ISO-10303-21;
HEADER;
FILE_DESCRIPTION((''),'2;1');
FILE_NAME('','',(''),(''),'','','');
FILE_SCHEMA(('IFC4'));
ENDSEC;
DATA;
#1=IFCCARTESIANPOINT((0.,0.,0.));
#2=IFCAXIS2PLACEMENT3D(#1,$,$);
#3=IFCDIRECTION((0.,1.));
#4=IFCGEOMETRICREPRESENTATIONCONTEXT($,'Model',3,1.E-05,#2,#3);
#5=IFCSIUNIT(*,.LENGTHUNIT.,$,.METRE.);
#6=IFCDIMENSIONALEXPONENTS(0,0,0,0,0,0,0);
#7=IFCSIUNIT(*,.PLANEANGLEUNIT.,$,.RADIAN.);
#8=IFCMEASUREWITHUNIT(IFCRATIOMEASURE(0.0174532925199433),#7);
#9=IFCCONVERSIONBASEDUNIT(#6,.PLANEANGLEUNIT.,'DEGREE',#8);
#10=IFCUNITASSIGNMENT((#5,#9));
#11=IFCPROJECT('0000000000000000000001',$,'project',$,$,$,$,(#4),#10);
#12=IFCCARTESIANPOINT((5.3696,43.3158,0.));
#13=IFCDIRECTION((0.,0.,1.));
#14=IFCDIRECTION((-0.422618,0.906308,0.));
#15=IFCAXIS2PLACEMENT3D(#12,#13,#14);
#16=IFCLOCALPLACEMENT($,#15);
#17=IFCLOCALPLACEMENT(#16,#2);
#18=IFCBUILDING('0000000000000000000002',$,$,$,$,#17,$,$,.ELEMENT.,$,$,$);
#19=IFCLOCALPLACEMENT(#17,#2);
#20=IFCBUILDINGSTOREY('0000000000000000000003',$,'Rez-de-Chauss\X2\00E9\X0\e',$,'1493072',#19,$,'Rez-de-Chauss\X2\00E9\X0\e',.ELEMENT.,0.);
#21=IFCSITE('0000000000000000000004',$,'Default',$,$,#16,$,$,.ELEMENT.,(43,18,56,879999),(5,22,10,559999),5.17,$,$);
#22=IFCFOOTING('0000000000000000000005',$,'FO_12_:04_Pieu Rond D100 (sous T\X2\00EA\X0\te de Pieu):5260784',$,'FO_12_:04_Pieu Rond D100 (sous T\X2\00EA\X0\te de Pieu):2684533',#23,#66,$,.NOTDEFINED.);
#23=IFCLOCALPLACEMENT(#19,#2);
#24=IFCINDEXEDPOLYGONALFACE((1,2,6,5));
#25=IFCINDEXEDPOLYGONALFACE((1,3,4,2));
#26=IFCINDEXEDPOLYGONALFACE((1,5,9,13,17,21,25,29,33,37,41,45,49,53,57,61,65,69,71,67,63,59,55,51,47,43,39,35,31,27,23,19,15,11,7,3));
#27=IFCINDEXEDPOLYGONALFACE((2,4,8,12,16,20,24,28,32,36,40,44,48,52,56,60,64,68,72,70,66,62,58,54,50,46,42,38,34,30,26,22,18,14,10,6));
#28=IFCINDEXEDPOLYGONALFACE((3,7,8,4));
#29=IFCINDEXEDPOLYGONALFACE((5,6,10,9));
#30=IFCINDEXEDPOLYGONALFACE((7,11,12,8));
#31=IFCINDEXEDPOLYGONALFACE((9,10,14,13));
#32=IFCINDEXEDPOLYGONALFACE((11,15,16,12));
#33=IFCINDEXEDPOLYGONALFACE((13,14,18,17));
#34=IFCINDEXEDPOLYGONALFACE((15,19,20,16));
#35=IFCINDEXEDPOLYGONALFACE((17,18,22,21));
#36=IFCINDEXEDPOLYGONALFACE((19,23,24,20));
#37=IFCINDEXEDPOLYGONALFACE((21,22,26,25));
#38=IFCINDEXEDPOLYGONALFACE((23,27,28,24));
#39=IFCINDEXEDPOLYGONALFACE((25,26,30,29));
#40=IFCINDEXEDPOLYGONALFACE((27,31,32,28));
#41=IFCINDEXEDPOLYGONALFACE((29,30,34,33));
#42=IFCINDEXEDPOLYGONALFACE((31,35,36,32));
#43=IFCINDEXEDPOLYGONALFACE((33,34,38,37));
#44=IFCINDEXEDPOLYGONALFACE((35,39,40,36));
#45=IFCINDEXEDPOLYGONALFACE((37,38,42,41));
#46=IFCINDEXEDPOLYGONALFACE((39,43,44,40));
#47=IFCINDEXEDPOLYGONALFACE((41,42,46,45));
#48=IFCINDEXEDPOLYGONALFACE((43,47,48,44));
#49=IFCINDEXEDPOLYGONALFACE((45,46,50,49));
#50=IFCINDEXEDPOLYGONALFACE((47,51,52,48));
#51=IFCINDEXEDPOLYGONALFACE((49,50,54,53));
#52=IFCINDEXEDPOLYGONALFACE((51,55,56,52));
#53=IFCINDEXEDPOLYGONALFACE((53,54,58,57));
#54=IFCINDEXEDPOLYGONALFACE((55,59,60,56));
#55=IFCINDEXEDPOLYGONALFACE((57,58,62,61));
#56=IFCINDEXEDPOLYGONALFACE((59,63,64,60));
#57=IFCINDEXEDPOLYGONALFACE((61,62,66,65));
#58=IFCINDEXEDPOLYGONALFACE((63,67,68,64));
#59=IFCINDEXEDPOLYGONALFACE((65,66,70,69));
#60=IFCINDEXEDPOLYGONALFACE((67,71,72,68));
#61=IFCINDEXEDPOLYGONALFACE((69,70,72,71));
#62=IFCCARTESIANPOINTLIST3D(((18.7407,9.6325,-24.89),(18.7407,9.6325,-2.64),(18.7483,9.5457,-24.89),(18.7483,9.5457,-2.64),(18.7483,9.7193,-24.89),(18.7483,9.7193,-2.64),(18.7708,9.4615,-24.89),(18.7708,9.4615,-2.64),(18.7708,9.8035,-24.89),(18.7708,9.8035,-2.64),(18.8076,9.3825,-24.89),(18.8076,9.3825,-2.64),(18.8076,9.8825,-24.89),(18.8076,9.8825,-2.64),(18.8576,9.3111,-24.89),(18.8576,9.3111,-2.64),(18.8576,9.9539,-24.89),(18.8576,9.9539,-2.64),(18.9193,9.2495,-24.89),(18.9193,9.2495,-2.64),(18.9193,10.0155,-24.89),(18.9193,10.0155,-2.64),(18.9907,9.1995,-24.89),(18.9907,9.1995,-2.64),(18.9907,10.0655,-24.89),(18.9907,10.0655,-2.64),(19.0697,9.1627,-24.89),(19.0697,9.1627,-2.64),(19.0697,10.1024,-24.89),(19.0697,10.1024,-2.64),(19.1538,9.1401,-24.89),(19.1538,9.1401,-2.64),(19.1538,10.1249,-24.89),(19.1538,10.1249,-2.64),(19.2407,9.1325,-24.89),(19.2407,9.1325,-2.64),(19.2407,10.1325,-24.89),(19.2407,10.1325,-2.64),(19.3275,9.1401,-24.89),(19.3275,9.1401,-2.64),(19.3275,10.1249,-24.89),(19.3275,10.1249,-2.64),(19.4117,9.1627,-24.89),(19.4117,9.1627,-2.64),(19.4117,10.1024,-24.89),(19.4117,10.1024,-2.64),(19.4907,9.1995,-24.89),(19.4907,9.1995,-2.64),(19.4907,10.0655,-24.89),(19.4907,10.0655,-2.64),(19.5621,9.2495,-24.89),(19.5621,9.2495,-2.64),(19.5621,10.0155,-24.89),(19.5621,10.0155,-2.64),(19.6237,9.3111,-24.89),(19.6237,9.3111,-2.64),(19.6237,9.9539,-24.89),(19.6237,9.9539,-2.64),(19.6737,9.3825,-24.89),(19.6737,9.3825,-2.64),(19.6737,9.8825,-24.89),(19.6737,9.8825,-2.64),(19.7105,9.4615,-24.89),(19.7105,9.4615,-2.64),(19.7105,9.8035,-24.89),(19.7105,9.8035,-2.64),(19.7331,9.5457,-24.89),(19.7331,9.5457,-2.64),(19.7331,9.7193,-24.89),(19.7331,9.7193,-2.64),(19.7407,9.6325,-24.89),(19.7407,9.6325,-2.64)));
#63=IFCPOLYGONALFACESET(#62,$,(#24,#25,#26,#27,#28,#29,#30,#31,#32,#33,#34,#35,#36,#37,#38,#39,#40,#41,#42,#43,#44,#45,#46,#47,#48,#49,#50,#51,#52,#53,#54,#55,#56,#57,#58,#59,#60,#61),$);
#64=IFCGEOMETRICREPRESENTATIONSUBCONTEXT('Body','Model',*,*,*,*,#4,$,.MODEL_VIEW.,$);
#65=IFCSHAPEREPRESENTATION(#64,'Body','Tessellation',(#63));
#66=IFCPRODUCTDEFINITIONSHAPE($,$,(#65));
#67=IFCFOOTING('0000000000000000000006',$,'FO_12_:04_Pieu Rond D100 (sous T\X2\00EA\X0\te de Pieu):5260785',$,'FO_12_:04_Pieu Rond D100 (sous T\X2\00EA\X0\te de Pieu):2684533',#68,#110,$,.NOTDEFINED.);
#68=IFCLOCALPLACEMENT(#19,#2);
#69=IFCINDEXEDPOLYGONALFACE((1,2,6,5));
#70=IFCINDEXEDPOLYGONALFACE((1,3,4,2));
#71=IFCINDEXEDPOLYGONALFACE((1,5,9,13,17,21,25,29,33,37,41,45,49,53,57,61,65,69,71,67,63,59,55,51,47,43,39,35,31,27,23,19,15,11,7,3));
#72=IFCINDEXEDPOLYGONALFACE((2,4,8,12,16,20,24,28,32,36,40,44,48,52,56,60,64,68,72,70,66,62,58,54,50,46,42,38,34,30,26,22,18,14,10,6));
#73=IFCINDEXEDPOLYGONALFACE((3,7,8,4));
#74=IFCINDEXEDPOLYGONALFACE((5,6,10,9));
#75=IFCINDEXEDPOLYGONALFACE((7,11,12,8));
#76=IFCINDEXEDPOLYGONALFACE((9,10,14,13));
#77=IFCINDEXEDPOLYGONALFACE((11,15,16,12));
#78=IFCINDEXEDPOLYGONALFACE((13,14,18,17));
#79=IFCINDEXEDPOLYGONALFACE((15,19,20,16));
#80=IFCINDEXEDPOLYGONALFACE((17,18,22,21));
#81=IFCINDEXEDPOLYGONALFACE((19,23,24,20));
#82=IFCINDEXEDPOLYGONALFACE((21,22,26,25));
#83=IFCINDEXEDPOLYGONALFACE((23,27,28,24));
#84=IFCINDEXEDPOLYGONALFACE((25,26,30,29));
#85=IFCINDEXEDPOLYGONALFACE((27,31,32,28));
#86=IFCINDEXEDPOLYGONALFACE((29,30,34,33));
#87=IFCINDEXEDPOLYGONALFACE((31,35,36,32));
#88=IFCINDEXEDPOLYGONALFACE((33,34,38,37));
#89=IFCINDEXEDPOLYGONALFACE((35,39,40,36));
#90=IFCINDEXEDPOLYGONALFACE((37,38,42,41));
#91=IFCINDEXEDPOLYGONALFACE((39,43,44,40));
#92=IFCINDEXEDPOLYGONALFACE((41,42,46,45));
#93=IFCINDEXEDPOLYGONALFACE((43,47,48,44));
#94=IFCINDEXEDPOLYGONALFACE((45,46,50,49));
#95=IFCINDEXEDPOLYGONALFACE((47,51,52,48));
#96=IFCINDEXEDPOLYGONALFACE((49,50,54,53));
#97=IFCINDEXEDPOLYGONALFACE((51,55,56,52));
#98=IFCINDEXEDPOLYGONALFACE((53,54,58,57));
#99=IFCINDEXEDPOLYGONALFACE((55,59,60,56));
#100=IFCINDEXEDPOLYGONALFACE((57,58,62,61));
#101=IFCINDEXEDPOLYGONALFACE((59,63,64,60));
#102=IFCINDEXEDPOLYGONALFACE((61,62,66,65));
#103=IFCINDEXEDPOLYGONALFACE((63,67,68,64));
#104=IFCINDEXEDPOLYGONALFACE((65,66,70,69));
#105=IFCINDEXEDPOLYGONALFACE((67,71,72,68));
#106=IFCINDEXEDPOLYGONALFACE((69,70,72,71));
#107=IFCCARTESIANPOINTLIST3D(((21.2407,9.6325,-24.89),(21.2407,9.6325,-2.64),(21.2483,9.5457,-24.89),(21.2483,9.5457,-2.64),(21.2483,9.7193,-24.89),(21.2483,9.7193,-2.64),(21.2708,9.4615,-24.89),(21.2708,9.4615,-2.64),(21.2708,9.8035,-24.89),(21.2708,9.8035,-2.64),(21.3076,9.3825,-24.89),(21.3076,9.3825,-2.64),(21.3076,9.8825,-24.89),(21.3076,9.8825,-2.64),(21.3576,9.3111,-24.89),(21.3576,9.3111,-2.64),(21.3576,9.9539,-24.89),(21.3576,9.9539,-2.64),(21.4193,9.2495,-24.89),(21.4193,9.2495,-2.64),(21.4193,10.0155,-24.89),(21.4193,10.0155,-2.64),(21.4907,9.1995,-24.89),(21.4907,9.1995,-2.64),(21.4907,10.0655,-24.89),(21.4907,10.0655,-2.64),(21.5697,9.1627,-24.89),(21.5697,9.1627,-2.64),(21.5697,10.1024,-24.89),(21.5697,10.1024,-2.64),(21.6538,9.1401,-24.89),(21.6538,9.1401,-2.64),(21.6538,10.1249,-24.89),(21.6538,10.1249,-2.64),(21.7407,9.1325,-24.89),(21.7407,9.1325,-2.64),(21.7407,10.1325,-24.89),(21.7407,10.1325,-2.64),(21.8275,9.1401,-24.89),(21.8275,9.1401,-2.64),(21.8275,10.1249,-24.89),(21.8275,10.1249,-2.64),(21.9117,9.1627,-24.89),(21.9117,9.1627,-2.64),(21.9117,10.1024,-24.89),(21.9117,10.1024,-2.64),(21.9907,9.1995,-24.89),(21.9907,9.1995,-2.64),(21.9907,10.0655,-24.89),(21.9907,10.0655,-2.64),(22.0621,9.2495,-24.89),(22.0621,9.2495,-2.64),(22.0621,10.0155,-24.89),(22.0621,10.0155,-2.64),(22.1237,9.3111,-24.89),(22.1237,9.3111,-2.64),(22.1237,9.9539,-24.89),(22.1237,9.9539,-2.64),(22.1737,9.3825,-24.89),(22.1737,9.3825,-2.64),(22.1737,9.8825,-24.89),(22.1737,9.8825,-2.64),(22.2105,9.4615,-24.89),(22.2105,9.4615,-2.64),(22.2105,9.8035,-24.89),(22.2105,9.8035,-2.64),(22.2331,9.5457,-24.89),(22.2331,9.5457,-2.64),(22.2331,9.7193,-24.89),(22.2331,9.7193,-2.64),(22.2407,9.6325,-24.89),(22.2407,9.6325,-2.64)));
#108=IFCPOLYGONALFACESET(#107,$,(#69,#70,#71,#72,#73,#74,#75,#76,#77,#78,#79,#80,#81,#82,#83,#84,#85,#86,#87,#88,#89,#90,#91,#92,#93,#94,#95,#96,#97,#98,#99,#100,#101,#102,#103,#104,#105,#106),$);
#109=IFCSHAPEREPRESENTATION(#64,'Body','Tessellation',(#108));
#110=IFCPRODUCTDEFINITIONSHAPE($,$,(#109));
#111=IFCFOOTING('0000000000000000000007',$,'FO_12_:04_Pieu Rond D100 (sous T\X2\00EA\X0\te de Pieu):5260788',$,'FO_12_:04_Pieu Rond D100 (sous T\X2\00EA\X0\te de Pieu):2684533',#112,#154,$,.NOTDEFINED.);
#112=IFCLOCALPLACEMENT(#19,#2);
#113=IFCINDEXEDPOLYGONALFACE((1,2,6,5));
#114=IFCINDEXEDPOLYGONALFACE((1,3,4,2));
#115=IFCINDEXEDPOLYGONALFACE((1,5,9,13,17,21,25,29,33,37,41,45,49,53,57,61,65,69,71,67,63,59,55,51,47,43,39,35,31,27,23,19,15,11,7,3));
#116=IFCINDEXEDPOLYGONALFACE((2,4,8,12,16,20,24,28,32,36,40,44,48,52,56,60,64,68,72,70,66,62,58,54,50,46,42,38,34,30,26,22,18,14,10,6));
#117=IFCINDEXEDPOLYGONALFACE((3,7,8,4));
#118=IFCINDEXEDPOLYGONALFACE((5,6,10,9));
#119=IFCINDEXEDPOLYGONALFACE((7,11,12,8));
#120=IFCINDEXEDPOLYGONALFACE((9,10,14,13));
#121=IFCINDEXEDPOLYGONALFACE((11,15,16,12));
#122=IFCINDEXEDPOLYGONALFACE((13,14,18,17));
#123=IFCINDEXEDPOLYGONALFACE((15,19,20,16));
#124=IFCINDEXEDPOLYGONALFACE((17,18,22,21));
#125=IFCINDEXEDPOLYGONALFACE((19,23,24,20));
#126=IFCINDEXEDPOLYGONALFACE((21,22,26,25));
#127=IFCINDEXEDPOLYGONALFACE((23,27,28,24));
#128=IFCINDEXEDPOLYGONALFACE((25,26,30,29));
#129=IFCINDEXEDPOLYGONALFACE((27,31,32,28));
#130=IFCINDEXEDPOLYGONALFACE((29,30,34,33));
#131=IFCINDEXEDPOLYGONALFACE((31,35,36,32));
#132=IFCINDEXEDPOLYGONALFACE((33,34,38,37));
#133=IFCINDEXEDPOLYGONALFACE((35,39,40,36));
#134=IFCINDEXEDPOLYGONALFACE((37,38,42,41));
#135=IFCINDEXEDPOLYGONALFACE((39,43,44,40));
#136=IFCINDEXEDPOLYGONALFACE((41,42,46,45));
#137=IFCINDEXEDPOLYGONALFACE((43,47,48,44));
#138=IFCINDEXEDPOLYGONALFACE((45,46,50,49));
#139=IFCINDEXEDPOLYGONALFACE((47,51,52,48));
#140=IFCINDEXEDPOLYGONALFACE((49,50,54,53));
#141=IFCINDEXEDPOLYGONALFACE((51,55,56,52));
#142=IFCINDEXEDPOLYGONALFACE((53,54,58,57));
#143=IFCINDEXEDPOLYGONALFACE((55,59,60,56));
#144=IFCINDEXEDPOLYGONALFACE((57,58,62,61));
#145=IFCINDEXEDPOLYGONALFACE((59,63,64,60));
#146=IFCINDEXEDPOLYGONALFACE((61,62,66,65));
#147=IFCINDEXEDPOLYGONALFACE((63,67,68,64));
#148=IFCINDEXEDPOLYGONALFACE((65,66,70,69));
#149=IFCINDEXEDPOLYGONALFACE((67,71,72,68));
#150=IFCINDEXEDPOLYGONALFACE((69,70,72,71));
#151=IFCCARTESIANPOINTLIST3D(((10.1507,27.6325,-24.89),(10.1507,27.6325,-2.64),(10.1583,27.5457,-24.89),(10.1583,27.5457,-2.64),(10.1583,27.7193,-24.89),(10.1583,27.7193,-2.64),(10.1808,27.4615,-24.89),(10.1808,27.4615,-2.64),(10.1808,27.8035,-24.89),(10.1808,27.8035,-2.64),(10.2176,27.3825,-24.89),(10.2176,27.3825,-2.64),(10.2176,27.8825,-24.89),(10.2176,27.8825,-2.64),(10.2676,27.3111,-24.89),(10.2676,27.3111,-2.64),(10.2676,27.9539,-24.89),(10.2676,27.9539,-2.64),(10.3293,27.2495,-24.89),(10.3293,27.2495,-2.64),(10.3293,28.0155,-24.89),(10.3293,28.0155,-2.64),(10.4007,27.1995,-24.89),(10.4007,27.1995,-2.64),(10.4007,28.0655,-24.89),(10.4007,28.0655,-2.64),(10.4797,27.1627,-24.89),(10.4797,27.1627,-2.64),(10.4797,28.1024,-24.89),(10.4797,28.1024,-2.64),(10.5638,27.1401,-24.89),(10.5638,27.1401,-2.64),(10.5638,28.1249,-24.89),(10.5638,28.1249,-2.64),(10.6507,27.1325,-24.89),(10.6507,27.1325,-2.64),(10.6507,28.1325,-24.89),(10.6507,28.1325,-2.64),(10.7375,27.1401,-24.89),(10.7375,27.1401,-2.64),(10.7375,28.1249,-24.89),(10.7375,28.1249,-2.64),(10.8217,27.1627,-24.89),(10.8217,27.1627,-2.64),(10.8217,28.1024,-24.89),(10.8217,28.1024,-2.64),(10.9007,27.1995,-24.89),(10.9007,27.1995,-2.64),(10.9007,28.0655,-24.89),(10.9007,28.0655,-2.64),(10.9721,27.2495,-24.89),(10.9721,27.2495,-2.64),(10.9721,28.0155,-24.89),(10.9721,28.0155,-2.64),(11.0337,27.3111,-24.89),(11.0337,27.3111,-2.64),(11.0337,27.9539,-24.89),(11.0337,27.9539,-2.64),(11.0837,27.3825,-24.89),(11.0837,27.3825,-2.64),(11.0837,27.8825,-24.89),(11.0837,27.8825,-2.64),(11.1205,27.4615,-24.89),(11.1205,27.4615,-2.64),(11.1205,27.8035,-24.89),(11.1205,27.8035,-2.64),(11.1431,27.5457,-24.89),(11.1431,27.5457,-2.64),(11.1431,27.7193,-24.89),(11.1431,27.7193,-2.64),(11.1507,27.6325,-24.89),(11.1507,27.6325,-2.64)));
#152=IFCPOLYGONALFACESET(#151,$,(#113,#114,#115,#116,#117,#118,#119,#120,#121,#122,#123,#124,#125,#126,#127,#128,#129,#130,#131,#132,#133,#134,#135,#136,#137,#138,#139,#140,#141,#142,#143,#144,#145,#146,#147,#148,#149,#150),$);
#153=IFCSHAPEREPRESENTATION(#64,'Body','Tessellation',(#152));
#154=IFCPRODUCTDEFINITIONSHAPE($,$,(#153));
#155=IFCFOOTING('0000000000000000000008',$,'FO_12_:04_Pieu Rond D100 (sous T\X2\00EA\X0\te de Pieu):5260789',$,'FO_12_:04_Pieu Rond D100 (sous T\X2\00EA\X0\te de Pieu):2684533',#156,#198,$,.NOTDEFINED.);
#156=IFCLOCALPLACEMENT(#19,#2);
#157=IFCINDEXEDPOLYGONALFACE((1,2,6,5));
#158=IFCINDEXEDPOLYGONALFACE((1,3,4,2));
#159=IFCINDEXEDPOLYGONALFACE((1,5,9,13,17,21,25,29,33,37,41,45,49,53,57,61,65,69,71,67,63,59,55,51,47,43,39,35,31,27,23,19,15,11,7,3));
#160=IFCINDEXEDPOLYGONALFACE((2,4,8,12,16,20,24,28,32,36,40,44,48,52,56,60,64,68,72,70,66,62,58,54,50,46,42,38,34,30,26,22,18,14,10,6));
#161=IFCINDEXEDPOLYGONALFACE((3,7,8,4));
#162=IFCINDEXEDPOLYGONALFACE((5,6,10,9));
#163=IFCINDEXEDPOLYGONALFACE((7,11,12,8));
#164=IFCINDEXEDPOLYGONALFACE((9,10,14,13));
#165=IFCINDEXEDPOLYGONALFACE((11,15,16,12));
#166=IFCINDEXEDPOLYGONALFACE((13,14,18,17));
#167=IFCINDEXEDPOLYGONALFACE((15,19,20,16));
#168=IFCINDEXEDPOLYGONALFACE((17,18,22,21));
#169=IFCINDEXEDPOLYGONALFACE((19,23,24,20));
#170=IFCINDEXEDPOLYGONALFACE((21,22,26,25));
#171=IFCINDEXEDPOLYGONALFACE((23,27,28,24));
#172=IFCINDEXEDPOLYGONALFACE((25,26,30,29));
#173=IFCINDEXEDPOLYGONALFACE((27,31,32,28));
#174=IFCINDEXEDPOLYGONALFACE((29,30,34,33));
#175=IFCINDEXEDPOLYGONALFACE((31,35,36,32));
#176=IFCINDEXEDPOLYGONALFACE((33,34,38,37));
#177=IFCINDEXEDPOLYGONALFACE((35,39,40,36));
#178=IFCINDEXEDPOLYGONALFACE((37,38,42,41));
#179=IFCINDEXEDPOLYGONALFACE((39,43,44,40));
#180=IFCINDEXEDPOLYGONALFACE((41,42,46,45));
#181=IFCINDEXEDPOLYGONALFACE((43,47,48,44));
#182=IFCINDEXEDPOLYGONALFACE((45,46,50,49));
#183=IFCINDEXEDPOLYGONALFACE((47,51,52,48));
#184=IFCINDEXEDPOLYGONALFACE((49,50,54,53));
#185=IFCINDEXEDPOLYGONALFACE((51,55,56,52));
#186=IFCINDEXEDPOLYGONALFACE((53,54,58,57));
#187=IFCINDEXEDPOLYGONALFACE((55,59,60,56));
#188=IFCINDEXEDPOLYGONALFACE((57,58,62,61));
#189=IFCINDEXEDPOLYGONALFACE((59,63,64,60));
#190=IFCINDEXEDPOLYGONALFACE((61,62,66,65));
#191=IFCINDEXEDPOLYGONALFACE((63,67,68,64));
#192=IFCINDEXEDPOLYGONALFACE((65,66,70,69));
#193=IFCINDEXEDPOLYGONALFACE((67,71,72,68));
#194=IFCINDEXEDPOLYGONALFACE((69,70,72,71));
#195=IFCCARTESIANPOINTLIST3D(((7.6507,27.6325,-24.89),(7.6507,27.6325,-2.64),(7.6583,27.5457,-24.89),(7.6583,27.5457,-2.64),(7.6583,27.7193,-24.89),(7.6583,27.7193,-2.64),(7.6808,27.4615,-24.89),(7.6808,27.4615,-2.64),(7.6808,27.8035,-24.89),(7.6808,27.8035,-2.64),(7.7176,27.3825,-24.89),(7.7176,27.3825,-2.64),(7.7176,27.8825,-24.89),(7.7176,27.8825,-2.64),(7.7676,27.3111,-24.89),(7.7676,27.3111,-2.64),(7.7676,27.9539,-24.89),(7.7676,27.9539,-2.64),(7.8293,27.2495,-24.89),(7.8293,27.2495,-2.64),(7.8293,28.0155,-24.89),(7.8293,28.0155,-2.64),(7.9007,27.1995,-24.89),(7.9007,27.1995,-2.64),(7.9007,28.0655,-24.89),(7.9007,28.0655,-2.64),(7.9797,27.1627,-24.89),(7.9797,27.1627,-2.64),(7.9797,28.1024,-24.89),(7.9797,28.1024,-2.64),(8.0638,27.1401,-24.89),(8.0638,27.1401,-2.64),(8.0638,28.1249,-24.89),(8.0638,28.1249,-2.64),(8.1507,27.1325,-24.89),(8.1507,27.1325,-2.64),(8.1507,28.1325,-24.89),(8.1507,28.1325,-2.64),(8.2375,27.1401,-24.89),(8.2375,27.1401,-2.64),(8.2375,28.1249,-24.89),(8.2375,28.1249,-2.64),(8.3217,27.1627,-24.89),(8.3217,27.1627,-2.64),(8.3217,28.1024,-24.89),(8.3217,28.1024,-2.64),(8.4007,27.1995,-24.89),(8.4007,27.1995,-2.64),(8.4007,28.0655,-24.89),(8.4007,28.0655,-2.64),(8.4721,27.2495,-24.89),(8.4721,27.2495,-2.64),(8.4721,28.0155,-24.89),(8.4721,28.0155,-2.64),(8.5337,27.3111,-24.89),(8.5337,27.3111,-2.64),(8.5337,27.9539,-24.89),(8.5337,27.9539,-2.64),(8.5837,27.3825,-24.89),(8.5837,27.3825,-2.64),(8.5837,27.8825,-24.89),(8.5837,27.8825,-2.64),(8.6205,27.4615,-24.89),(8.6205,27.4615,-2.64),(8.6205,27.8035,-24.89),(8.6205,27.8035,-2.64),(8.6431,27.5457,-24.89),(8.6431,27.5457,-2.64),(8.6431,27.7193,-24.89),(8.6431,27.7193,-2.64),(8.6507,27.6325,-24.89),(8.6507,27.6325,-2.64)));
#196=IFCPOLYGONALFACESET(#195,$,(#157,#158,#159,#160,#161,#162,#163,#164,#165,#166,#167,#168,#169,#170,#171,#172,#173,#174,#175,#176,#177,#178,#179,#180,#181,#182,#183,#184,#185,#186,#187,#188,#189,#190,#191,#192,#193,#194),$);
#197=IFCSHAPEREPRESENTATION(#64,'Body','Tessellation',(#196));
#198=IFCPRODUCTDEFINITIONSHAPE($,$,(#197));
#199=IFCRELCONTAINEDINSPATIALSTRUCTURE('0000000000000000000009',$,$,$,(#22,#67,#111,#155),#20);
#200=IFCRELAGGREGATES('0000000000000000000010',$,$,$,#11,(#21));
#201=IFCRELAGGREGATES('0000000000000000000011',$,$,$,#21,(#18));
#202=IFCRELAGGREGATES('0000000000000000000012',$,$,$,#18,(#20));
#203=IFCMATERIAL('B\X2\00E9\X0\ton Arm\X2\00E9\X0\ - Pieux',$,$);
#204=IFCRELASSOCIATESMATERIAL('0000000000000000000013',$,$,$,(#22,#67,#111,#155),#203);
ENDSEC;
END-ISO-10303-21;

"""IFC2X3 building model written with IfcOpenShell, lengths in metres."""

from ifc_helpers import new_model, entity, si_unit, converted_unit, direction, frame, frame_2d, origin, origin_2d_with_axis, place, context, subcontext, project, spatial, circle, extrude, material, element, save


model = new_model("IFC2X3")

# Units and contexts
model_context = context("Model", 3, precision=1e-05, world=origin(), true_north=direction((0.0, 1.0)))
body_context = subcontext(model_context, "Body", "Model", "MODEL_VIEW")
ifc_project = project(units=[si_unit("LENGTHUNIT", "METRE"), converted_unit("PLANEANGLEUNIT", "DEGREE", entity("IfcRatioMeasure", 0.0174532925199433), si_unit("PLANEANGLEUNIT", "RADIAN"), dimensions=[0, 0, 0, 0, 0, 0, 0])], contexts=[model_context])

# Site, building, storey
site_placement = place(None, frame((5.3696, 43.3158, 0.0), z_axis=(0.0, 0.0, 1.0), x_axis=(-0.422618, 0.906308, 0.0)))
site = spatial("IfcSite", under=ifc_project, at=site_placement, Name="Default", CompositionType="ELEMENT", RefLatitude=(43, 18, 56, 879999), RefLongitude=(5, 22, 10, 559999), RefElevation=5.17)
building_placement = place(site_placement, origin())
building = spatial("IfcBuilding", under=site, at=building_placement, CompositionType="ELEMENT")
storey_placement = place(building_placement, origin())
storey = spatial("IfcBuildingStorey", under=building, at=storey_placement, Name="Rez-de-Chaussée", ObjectType="1493072", LongName="Rez-de-Chaussée", CompositionType="ELEMENT", Elevation=0.0)

# Footings
ifc_material_1 = material(Name="Béton Armé - Pieux")
footing_1_placement = place(storey_placement, origin())
element("IfcFooting", 1, at=footing_1_placement, inside=storey, material=ifc_material_1, Name="FO_12_:04_Pieu Rond D100 (sous Tête de Pieu):5260784", ObjectType="FO_12_:04_Pieu Rond D100 (sous Tête de Pieu):2684533", PredefinedType="NOTDEFINED", context=body_context, shape_type="SweptSolid", body=[
    extrude(circle(Radius=0.5, at=frame_2d((0.0, 0.0), x_axis=(1.0, 0.0))), frame((19.2407, 9.6325, -24.89)), (0.0, 0.0, 1.0), 22.25),
])
footing_2_placement = place(storey_placement, origin())
element("IfcFooting", 2, at=footing_2_placement, inside=storey, material=ifc_material_1, Name="FO_12_:04_Pieu Rond D100 (sous Tête de Pieu):5260785", ObjectType="FO_12_:04_Pieu Rond D100 (sous Tête de Pieu):2684533", PredefinedType="NOTDEFINED", context=body_context, shape_type="SweptSolid", body=[
    extrude(circle(Radius=0.5, at=frame_2d((0.0, 0.0), x_axis=(1.0, 0.0))), frame((21.7407, 9.6325, -24.89)), (0.0, 0.0, 1.0), 22.25),
])
footing_3_placement = place(storey_placement, origin())
element("IfcFooting", 3, at=footing_3_placement, inside=storey, material=ifc_material_1, Name="FO_12_:04_Pieu Rond D100 (sous Tête de Pieu):5260788", ObjectType="FO_12_:04_Pieu Rond D100 (sous Tête de Pieu):2684533", PredefinedType="NOTDEFINED", context=body_context, shape_type="SweptSolid", body=[
    extrude(circle(Radius=0.5, at=origin_2d_with_axis()), frame((10.6507, 27.6325, -24.89), z_axis=(0.0, 0.0, 1.0), x_axis=(-1.0, 0.0, 0.0)), (0.0, 0.0, 1.0), 22.25),
])
footing_4_placement = place(storey_placement, origin())
element("IfcFooting", 4, at=footing_4_placement, inside=storey, material=ifc_material_1, Name="FO_12_:04_Pieu Rond D100 (sous Tête de Pieu):5260789", ObjectType="FO_12_:04_Pieu Rond D100 (sous Tête de Pieu):2684533", PredefinedType="NOTDEFINED", context=body_context, shape_type="SweptSolid", body=[
    extrude(circle(Radius=0.5, at=origin_2d_with_axis()), frame((8.1507, 27.6325, -24.89), z_axis=(0.0, 0.0, 1.0), x_axis=(-1.0, 0.0, 0.0)), (0.0, 0.0, 1.0), 22.25),
])

save(model, "model.ifc")
